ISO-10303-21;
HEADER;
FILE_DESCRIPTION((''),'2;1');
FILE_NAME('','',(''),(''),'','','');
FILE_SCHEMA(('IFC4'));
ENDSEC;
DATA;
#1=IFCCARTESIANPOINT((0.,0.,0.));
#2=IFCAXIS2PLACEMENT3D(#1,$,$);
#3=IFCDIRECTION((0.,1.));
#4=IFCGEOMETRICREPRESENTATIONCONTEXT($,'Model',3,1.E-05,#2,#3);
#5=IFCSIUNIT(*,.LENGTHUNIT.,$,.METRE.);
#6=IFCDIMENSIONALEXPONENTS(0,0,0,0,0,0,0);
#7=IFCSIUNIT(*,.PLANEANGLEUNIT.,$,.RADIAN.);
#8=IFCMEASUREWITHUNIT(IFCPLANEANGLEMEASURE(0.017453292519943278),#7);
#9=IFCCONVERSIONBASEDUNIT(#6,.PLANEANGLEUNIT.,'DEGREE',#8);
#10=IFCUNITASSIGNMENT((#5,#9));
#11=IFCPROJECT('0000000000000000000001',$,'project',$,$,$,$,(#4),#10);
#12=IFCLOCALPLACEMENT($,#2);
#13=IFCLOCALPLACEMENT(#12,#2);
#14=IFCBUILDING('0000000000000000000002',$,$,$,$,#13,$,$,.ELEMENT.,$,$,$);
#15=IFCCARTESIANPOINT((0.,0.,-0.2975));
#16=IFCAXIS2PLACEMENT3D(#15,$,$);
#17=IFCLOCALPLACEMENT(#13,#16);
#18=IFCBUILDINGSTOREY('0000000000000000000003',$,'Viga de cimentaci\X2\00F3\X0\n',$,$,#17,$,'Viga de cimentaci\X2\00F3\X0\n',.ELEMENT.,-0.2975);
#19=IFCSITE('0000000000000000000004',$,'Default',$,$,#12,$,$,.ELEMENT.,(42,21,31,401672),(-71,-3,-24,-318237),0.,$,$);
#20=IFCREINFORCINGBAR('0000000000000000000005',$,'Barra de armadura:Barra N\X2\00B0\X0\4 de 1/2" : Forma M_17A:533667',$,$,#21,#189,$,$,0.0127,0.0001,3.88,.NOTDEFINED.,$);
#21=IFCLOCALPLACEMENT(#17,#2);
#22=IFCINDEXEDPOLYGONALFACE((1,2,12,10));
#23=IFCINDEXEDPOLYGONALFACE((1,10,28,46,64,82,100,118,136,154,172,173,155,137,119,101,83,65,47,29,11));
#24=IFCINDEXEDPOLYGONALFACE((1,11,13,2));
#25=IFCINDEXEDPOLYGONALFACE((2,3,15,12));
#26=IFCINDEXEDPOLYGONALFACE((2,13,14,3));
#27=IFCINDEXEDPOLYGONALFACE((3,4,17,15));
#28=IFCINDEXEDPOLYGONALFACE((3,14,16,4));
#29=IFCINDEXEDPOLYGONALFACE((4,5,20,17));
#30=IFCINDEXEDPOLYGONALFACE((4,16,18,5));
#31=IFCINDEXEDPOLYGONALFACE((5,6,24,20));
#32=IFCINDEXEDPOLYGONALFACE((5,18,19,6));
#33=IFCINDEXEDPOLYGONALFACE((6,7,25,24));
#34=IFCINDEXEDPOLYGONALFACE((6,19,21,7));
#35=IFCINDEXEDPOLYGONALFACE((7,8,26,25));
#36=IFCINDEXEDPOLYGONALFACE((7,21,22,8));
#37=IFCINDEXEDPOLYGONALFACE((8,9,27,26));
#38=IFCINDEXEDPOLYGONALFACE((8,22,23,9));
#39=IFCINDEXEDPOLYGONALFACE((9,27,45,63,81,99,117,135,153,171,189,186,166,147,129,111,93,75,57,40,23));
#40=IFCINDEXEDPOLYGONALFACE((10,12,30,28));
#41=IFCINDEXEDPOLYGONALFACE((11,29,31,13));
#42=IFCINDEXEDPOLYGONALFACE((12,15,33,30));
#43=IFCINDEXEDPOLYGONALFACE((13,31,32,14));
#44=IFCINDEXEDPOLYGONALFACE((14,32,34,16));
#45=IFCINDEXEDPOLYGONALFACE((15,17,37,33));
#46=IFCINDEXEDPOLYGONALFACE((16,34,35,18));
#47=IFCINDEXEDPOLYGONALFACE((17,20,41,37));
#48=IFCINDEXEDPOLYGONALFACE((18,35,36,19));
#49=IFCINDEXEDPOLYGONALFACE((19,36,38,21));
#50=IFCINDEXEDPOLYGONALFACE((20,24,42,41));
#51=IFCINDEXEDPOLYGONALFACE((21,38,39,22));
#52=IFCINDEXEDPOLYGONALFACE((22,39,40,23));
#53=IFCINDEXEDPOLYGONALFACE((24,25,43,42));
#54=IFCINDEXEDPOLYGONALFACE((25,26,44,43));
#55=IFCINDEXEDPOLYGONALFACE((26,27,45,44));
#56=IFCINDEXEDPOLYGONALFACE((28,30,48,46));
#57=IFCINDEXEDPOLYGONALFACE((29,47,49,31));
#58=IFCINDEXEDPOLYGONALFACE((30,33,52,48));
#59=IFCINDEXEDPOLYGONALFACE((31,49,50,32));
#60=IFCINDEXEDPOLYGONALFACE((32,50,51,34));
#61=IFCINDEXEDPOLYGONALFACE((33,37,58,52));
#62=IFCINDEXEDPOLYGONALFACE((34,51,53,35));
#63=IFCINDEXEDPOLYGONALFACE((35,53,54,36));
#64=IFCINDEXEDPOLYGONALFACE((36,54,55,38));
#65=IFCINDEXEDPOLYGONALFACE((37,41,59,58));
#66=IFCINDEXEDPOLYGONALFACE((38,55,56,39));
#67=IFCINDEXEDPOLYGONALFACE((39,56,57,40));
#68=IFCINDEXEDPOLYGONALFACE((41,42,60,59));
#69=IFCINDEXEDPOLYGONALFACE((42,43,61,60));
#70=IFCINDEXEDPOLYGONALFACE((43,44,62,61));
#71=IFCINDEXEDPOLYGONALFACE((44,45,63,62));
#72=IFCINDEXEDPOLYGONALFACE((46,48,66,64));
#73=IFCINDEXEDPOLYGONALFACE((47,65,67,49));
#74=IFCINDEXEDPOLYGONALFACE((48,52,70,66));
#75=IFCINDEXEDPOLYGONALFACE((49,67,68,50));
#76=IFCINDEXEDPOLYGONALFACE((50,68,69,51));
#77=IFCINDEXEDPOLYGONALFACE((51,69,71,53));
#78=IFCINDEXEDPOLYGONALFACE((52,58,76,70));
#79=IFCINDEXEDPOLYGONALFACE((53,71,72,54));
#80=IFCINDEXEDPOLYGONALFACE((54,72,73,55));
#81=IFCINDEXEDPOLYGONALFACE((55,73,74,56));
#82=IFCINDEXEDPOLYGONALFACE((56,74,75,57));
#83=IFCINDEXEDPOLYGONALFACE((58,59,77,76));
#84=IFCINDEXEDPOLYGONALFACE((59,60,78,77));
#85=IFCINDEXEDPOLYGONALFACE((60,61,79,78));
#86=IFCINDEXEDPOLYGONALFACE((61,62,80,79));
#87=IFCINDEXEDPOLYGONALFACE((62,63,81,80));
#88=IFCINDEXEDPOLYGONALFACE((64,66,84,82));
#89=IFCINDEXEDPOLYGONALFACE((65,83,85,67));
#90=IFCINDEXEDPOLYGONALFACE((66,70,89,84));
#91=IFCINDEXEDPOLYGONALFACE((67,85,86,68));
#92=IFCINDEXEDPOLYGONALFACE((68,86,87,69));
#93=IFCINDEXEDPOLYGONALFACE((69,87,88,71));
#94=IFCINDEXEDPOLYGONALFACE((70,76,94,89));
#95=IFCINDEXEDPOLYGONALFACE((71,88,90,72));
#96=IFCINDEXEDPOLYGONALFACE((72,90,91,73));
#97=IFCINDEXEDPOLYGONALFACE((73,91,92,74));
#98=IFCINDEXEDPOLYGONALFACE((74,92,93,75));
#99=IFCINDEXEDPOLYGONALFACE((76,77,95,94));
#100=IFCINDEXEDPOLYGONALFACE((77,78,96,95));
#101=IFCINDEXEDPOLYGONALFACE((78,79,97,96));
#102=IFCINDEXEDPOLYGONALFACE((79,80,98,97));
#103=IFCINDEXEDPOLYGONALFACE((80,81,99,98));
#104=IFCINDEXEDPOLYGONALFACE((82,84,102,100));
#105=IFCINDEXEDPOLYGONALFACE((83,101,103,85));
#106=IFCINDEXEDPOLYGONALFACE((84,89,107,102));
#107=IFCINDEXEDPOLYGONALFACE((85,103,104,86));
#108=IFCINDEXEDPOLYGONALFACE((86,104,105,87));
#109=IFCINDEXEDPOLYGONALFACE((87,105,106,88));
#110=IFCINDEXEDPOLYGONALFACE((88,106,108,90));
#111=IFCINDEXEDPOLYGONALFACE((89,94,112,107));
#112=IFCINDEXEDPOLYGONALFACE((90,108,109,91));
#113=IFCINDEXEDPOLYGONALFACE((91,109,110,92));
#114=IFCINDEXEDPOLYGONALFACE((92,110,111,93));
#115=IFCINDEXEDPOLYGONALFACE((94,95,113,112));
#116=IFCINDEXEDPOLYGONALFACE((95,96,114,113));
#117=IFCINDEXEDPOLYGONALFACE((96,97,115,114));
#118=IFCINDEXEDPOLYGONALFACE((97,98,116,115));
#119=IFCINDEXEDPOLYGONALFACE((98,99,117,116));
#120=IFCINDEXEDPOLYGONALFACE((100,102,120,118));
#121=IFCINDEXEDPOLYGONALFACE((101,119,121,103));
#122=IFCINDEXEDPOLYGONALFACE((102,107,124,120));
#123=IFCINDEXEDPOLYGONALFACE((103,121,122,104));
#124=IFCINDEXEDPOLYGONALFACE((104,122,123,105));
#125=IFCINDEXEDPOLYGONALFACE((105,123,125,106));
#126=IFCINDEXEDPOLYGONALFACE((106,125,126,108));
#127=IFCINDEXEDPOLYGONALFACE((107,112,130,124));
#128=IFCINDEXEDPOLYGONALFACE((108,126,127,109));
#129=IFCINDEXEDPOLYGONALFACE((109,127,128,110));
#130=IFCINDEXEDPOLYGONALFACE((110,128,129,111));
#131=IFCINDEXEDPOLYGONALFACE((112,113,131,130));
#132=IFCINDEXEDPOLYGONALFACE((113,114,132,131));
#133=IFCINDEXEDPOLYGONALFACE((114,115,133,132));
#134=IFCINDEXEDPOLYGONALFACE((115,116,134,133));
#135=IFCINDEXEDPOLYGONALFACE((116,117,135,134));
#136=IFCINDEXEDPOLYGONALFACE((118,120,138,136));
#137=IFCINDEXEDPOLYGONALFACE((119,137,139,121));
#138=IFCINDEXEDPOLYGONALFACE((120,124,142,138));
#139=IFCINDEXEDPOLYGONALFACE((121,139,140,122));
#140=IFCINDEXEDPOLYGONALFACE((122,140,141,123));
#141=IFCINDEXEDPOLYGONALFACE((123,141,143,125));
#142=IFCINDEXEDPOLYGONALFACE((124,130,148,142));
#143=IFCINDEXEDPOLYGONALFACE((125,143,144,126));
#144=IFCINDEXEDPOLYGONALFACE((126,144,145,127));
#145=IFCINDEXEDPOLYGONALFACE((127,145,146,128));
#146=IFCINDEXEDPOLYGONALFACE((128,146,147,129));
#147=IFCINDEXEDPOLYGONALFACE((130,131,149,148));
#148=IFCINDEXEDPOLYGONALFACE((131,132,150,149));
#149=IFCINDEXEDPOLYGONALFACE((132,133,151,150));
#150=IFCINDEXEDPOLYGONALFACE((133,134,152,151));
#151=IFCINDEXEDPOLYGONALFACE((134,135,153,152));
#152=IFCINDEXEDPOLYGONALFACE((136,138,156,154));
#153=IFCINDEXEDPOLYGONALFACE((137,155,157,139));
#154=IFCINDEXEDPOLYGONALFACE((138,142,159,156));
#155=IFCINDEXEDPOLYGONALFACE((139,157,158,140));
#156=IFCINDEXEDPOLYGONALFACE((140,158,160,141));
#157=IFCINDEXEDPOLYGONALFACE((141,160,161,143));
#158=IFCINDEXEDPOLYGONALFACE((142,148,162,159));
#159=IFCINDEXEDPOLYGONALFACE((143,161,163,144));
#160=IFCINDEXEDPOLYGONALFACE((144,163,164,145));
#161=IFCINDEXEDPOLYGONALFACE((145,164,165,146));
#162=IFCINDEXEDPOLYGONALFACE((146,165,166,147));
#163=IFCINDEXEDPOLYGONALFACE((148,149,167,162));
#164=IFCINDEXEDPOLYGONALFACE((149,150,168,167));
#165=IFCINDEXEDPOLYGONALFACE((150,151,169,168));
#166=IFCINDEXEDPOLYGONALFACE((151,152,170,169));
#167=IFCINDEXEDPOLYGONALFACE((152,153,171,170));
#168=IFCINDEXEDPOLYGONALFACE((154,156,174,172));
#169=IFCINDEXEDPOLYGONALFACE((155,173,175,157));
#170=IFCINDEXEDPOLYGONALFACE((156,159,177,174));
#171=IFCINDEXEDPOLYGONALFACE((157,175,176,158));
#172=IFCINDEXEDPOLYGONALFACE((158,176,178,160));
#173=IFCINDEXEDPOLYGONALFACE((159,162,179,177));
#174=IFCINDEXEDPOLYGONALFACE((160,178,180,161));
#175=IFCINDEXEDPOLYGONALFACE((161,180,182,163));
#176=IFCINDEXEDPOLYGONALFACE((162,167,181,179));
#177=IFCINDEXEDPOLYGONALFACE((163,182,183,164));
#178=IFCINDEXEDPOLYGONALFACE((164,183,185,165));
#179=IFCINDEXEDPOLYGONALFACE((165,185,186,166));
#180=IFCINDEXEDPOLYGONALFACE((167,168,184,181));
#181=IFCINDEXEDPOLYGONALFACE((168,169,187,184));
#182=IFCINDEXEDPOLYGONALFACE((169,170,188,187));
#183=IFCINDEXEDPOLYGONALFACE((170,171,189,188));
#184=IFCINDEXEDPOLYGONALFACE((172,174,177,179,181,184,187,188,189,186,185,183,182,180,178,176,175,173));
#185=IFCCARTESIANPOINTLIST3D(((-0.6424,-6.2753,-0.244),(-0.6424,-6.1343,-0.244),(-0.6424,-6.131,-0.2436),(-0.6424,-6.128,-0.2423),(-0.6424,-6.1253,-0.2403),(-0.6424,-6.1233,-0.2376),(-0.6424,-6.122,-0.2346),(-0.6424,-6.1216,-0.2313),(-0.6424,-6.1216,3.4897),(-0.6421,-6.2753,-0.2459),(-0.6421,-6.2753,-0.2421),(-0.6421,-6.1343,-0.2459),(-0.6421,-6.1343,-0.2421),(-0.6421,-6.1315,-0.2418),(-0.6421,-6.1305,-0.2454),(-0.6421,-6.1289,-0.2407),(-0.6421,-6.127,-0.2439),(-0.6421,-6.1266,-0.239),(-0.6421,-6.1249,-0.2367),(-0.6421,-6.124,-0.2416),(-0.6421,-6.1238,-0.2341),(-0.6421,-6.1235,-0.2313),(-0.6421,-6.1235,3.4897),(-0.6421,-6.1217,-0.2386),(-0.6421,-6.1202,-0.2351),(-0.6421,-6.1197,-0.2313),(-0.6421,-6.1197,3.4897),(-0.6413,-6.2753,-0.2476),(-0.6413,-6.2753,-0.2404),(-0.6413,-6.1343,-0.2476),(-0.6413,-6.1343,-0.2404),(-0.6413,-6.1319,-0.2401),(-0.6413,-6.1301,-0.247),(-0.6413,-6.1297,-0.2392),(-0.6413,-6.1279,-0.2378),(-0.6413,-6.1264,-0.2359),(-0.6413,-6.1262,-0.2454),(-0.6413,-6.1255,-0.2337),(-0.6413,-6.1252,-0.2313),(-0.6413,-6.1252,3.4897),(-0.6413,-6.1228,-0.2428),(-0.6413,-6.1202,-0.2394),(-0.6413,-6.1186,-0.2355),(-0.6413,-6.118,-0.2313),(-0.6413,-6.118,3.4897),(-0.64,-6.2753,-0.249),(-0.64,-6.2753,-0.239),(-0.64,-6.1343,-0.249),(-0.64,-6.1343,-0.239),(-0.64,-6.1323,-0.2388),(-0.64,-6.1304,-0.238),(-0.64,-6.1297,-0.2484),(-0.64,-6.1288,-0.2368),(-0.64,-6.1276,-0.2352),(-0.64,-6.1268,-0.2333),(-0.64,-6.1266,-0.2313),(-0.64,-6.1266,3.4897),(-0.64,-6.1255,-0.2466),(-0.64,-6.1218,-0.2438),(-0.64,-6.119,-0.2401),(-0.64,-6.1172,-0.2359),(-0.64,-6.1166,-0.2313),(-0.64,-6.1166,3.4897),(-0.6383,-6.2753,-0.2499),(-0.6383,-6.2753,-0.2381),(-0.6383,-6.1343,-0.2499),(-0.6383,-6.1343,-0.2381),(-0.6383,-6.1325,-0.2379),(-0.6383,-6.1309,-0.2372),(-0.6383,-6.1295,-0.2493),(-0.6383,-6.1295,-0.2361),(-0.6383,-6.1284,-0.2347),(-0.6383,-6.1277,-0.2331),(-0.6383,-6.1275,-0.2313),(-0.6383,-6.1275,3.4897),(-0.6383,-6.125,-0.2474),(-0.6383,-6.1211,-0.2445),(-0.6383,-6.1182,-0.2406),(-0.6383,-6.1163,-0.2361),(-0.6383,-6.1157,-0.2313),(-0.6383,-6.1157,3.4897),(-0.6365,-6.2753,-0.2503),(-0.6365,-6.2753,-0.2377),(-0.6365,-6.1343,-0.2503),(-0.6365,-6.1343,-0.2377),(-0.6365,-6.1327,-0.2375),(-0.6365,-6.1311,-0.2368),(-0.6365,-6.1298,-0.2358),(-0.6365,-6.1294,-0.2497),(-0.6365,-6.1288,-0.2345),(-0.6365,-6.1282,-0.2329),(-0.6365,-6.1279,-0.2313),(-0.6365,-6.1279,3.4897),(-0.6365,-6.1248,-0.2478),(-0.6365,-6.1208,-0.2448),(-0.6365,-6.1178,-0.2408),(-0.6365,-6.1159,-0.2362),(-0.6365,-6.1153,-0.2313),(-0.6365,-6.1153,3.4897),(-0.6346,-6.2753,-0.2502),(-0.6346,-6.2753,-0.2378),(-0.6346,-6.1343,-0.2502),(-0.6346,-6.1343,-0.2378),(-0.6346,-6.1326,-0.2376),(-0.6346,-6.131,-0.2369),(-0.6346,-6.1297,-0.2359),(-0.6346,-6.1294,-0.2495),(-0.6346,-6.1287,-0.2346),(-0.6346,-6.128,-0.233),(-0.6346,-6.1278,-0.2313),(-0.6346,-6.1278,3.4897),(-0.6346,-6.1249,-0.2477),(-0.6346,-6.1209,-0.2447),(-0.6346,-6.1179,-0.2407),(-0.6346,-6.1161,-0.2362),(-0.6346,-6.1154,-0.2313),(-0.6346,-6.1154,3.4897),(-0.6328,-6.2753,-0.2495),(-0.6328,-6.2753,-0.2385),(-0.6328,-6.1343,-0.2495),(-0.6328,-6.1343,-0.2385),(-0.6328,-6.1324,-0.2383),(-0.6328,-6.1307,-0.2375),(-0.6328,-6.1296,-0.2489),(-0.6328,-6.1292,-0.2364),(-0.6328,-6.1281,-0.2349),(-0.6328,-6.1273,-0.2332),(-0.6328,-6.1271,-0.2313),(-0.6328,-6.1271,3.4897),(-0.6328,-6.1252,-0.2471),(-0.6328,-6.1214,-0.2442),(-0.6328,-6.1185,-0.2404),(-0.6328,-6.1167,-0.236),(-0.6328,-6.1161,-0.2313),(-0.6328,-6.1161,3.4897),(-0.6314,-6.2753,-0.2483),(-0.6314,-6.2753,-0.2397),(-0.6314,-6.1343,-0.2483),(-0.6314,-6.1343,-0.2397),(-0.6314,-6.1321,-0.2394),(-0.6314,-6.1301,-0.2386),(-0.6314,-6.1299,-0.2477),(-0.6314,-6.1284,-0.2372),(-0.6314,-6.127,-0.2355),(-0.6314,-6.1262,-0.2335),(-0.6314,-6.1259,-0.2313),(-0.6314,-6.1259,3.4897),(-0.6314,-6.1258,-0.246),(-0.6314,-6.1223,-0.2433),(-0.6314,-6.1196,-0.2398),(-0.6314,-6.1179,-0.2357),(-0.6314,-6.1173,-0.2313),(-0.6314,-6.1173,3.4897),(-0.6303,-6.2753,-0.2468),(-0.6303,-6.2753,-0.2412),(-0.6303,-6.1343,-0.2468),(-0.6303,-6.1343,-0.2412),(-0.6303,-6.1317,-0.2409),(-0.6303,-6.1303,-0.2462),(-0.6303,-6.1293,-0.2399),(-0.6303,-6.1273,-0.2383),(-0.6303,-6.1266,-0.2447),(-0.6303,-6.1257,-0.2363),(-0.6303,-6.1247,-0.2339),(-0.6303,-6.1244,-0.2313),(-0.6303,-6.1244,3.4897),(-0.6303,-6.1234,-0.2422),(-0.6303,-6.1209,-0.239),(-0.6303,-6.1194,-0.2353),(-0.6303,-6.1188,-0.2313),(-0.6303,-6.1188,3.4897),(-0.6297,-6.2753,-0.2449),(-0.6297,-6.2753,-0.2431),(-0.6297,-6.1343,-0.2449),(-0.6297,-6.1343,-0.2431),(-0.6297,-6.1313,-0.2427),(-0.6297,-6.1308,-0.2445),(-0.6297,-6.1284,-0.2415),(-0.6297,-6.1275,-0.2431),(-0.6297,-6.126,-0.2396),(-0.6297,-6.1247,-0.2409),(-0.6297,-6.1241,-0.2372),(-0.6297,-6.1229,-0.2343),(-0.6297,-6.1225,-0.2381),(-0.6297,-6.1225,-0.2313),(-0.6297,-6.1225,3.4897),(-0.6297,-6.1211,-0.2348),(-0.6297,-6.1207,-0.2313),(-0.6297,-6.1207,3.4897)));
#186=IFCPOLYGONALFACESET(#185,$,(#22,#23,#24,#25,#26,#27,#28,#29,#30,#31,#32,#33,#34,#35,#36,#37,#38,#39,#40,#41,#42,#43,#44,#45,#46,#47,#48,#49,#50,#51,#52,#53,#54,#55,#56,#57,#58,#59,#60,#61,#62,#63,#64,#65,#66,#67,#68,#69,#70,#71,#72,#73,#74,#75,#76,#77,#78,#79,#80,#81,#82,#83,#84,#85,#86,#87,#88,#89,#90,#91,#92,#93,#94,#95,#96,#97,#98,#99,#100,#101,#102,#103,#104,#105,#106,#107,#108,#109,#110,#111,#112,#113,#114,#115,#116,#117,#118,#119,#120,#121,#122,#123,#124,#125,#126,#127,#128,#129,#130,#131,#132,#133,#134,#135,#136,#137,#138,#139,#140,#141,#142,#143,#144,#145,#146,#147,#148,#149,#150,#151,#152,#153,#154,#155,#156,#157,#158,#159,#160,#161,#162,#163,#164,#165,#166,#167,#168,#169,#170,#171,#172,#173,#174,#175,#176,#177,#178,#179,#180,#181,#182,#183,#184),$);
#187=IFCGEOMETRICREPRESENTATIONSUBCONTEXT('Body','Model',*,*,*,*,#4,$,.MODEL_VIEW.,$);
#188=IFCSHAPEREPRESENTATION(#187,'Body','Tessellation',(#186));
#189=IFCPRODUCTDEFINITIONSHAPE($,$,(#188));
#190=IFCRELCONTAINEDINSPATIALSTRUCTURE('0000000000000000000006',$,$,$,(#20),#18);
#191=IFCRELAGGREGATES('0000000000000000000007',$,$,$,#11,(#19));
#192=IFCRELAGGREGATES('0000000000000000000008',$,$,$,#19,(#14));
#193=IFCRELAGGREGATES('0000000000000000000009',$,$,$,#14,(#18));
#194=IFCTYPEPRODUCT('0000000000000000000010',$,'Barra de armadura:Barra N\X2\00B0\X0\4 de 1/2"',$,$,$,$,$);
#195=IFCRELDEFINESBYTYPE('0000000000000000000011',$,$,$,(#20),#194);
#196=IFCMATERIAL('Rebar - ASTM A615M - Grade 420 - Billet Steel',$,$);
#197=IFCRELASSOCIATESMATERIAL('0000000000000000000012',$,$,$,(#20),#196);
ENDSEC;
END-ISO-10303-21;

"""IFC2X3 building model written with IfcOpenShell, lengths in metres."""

from ifc_helpers import new_model, entity, si_unit, converted_unit, direction, frame, origin, place, context, subcontext, project, spatial, material, type_object, element, save


model = new_model("IFC2X3")

# Units and contexts
model_context = context("Model", 3, precision=1e-05, world=origin(), true_north=direction((0.0, 1.0)))
body_context = subcontext(model_context, "Body", "Model", "MODEL_VIEW")
ifc_project = project(units=[si_unit("LENGTHUNIT", "METRE"), converted_unit("PLANEANGLEUNIT", "DEGREE", entity("IfcPlaneAngleMeasure", 0.017453292519943278), si_unit("PLANEANGLEUNIT", "RADIAN"), dimensions=[0, 0, 0, 0, 0, 0, 0])], contexts=[model_context])

# Site, building, storey
site_placement = place(None, origin())
site = spatial("IfcSite", under=ifc_project, at=site_placement, Name="Default", CompositionType="ELEMENT", RefLatitude=(42, 21, 31, 401672), RefLongitude=(-71, -3, -24, -318237), RefElevation=0.0)
building_placement = place(site_placement, origin())
building = spatial("IfcBuilding", under=site, at=building_placement, CompositionType="ELEMENT")
storey_placement = place(building_placement, frame((0.0, 0.0, -0.2975)))
storey = spatial("IfcBuildingStorey", under=building, at=storey_placement, Name="Viga de cimentación", LongName="Viga de cimentación", CompositionType="ELEMENT", Elevation=-0.2975)

# Reinforcing bar
ifc_material = material(Name="Rebar - ASTM A615M - Grade 420 - Billet Steel")
type_product_1 = type_object("IfcTypeProduct", Name="Barra de armadura:Barra N°4 de 1/2\"")
reinforcing_bar_1_placement = place(storey_placement, origin())
element("IfcReinforcingBar", 1, at=reinforcing_bar_1_placement, inside=storey, type_object=type_product_1, material=ifc_material, Name="Barra de armadura:Barra N°4 de 1/2\" : Forma M_17A:533667", BarLength=3.88, BarRole="NOTDEFINED", CrossSectionArea=0.0001, NominalDiameter=0.0127, context=body_context, shape_type="AdvancedSweptSolid", body=[
    entity("IfcSweptDiskSolid", entity("IfcCompositeCurve", [entity("IfcCompositeCurveSegment", "CONTINUOUS", True, entity("IfcPolyline", [entity("IfcCartesianPoint", [-0.636, -6.1216, 3.4897]), entity("IfcCartesianPoint", [-0.636, -6.1216, -0.2313])])), entity("IfcCompositeCurveSegment", "CONTINUOUS", True, entity("IfcTrimmedCurve", entity("IfcCircle", entity("IfcAxis2Placement3D", entity("IfcCartesianPoint", [-0.636, -6.1343, -0.2313]), entity("IfcDirection", [-1.0, 0.0, 0.0]), entity("IfcDirection", [0.0, 0.0, -1.0])), 0.0127), [entity("IfcParameterValue", 270.0)], [entity("IfcParameterValue", 360.0)], True, "PARAMETER")), entity("IfcCompositeCurveSegment", "CONTINUOUS", True, entity("IfcPolyline", [entity("IfcCartesianPoint", [-0.636, -6.1343, -0.244]), entity("IfcCartesianPoint", [-0.636, -6.2753, -0.244])]))], False), 0.0063, None, 0.0, 92.0),
])

save(model, "model.ifc")
